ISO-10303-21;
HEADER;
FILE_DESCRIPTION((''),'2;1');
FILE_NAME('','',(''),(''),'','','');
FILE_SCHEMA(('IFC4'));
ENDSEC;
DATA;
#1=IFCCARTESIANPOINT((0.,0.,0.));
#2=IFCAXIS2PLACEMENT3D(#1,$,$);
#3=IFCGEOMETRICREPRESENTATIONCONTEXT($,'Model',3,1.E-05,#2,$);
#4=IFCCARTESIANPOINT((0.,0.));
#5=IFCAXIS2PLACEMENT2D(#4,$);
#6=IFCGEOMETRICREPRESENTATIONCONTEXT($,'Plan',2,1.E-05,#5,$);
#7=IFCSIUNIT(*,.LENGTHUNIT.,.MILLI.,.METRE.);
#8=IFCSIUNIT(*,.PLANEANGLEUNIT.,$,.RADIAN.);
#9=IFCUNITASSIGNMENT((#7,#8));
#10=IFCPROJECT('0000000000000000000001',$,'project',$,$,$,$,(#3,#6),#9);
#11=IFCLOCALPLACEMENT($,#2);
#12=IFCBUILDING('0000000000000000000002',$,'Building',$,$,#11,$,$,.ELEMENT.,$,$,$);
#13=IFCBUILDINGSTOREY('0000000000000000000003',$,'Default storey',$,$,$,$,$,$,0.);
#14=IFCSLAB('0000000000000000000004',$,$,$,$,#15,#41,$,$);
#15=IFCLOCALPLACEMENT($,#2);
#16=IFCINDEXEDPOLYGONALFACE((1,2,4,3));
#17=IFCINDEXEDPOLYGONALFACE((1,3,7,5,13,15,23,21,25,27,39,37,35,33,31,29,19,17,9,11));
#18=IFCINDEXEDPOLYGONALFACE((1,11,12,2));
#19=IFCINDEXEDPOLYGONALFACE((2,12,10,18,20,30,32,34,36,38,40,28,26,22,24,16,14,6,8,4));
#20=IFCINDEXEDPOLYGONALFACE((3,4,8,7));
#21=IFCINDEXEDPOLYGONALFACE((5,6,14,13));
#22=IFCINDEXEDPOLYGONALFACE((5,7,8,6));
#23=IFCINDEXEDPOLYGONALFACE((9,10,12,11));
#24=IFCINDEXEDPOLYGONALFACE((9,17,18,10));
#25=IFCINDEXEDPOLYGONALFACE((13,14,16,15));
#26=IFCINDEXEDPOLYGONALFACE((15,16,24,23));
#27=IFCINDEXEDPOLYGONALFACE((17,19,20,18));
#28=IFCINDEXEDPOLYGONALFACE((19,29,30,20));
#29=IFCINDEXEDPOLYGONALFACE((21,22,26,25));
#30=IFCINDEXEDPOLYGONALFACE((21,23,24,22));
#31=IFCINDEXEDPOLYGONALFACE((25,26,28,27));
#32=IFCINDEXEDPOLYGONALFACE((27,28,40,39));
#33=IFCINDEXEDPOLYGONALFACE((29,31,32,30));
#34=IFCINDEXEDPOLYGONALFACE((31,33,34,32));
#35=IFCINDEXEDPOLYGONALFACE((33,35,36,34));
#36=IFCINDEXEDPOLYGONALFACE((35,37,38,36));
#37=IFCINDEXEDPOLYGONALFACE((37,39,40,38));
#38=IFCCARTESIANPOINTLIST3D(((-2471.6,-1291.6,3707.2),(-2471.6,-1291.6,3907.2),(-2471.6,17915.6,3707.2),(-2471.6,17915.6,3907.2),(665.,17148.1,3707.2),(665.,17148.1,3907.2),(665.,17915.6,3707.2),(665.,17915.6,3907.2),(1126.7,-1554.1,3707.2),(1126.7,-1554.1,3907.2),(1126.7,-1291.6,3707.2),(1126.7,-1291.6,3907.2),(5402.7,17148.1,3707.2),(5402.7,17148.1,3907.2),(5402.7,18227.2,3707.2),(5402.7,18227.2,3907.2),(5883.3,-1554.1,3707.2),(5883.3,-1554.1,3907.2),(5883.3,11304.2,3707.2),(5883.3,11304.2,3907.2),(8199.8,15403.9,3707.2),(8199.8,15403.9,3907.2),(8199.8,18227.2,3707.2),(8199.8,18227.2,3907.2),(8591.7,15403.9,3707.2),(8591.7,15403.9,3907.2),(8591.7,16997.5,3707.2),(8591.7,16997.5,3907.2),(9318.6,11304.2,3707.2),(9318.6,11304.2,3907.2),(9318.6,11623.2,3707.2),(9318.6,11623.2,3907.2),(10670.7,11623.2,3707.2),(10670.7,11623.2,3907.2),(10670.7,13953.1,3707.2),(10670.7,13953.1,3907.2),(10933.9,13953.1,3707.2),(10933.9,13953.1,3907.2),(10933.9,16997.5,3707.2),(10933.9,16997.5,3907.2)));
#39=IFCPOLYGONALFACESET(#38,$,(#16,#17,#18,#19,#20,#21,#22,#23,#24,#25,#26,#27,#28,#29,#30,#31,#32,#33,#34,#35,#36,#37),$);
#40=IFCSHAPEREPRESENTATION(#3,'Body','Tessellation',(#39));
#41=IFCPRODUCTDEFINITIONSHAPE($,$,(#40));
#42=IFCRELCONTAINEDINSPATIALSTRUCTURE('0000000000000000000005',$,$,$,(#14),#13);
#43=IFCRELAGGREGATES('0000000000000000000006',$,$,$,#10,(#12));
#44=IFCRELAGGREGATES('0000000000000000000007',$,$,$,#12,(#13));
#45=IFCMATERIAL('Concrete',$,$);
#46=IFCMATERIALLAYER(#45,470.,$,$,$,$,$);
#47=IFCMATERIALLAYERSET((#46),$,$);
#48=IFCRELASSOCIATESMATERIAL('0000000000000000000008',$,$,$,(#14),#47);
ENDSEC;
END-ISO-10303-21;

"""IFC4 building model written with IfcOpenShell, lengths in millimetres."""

from ifc_helpers import new_model, si_unit, frame, origin, origin_2d, place, context, project, spatial, polyline, outline, extrude, material, layer, layer_set, layer_usage, element, save


model = new_model("IFC4")

# Units and contexts
model_context = context("Model", 3, precision=1e-05, world=origin())
plan_context = context("Plan", 2, precision=1e-05, world=origin_2d())
ifc_project = project(units=[si_unit("LENGTHUNIT", "METRE", prefix="MILLI"), si_unit("PLANEANGLEUNIT", "RADIAN")], contexts=[model_context, plan_context])

# Building, storey
placement = place(None, origin())
building = spatial("IfcBuilding", under=ifc_project, at=placement, Name="Building", CompositionType="ELEMENT")
storey = spatial("IfcBuildingStorey", under=building, Name="Default storey", Elevation=0.0)

# Slab
ifc_material_1 = material(Name="Concrete")
ifc_layer = layer(ifc_material_1, 470.0)
ifc_layer_set = layer_set([ifc_layer])
ifc_layer_usage = layer_usage(ifc_layer_set, "AXIS3", "POSITIVE", 0.0)
element("IfcSlab", 1, at=placement, inside=storey, material=ifc_layer_usage, context=model_context, shape_type="SweptSolid", body=[
    extrude(outline(polyline([(8591.7, 16997.5), (8591.7, 15403.9), (8199.8, 15403.9), (8199.8, 18227.2), (5402.7, 18227.2), (5402.7, 17148.1), (665.0, 17148.1), (665.0, 17915.6), (-2471.6, 17915.6), (-2471.6, -1291.6), (1126.7, -1291.6), (1126.7, -1554.1), (5883.3, -1554.1), (5883.3, 11304.2), (9318.6, 11304.2), (9318.6, 11623.2), (10670.7, 11623.2), (10670.7, 13953.1), (10933.9, 13953.1), (10933.9, 16997.5), (8591.7, 16997.5)])), frame((0.0, 0.0, 3907.2), z_axis=(0.0, 0.0, 1000.0), x_axis=(1000.0, 0.0, 0.0)), (0.0, 0.0, -1.0), 200.0),
])

save(model, "model.ifc")
